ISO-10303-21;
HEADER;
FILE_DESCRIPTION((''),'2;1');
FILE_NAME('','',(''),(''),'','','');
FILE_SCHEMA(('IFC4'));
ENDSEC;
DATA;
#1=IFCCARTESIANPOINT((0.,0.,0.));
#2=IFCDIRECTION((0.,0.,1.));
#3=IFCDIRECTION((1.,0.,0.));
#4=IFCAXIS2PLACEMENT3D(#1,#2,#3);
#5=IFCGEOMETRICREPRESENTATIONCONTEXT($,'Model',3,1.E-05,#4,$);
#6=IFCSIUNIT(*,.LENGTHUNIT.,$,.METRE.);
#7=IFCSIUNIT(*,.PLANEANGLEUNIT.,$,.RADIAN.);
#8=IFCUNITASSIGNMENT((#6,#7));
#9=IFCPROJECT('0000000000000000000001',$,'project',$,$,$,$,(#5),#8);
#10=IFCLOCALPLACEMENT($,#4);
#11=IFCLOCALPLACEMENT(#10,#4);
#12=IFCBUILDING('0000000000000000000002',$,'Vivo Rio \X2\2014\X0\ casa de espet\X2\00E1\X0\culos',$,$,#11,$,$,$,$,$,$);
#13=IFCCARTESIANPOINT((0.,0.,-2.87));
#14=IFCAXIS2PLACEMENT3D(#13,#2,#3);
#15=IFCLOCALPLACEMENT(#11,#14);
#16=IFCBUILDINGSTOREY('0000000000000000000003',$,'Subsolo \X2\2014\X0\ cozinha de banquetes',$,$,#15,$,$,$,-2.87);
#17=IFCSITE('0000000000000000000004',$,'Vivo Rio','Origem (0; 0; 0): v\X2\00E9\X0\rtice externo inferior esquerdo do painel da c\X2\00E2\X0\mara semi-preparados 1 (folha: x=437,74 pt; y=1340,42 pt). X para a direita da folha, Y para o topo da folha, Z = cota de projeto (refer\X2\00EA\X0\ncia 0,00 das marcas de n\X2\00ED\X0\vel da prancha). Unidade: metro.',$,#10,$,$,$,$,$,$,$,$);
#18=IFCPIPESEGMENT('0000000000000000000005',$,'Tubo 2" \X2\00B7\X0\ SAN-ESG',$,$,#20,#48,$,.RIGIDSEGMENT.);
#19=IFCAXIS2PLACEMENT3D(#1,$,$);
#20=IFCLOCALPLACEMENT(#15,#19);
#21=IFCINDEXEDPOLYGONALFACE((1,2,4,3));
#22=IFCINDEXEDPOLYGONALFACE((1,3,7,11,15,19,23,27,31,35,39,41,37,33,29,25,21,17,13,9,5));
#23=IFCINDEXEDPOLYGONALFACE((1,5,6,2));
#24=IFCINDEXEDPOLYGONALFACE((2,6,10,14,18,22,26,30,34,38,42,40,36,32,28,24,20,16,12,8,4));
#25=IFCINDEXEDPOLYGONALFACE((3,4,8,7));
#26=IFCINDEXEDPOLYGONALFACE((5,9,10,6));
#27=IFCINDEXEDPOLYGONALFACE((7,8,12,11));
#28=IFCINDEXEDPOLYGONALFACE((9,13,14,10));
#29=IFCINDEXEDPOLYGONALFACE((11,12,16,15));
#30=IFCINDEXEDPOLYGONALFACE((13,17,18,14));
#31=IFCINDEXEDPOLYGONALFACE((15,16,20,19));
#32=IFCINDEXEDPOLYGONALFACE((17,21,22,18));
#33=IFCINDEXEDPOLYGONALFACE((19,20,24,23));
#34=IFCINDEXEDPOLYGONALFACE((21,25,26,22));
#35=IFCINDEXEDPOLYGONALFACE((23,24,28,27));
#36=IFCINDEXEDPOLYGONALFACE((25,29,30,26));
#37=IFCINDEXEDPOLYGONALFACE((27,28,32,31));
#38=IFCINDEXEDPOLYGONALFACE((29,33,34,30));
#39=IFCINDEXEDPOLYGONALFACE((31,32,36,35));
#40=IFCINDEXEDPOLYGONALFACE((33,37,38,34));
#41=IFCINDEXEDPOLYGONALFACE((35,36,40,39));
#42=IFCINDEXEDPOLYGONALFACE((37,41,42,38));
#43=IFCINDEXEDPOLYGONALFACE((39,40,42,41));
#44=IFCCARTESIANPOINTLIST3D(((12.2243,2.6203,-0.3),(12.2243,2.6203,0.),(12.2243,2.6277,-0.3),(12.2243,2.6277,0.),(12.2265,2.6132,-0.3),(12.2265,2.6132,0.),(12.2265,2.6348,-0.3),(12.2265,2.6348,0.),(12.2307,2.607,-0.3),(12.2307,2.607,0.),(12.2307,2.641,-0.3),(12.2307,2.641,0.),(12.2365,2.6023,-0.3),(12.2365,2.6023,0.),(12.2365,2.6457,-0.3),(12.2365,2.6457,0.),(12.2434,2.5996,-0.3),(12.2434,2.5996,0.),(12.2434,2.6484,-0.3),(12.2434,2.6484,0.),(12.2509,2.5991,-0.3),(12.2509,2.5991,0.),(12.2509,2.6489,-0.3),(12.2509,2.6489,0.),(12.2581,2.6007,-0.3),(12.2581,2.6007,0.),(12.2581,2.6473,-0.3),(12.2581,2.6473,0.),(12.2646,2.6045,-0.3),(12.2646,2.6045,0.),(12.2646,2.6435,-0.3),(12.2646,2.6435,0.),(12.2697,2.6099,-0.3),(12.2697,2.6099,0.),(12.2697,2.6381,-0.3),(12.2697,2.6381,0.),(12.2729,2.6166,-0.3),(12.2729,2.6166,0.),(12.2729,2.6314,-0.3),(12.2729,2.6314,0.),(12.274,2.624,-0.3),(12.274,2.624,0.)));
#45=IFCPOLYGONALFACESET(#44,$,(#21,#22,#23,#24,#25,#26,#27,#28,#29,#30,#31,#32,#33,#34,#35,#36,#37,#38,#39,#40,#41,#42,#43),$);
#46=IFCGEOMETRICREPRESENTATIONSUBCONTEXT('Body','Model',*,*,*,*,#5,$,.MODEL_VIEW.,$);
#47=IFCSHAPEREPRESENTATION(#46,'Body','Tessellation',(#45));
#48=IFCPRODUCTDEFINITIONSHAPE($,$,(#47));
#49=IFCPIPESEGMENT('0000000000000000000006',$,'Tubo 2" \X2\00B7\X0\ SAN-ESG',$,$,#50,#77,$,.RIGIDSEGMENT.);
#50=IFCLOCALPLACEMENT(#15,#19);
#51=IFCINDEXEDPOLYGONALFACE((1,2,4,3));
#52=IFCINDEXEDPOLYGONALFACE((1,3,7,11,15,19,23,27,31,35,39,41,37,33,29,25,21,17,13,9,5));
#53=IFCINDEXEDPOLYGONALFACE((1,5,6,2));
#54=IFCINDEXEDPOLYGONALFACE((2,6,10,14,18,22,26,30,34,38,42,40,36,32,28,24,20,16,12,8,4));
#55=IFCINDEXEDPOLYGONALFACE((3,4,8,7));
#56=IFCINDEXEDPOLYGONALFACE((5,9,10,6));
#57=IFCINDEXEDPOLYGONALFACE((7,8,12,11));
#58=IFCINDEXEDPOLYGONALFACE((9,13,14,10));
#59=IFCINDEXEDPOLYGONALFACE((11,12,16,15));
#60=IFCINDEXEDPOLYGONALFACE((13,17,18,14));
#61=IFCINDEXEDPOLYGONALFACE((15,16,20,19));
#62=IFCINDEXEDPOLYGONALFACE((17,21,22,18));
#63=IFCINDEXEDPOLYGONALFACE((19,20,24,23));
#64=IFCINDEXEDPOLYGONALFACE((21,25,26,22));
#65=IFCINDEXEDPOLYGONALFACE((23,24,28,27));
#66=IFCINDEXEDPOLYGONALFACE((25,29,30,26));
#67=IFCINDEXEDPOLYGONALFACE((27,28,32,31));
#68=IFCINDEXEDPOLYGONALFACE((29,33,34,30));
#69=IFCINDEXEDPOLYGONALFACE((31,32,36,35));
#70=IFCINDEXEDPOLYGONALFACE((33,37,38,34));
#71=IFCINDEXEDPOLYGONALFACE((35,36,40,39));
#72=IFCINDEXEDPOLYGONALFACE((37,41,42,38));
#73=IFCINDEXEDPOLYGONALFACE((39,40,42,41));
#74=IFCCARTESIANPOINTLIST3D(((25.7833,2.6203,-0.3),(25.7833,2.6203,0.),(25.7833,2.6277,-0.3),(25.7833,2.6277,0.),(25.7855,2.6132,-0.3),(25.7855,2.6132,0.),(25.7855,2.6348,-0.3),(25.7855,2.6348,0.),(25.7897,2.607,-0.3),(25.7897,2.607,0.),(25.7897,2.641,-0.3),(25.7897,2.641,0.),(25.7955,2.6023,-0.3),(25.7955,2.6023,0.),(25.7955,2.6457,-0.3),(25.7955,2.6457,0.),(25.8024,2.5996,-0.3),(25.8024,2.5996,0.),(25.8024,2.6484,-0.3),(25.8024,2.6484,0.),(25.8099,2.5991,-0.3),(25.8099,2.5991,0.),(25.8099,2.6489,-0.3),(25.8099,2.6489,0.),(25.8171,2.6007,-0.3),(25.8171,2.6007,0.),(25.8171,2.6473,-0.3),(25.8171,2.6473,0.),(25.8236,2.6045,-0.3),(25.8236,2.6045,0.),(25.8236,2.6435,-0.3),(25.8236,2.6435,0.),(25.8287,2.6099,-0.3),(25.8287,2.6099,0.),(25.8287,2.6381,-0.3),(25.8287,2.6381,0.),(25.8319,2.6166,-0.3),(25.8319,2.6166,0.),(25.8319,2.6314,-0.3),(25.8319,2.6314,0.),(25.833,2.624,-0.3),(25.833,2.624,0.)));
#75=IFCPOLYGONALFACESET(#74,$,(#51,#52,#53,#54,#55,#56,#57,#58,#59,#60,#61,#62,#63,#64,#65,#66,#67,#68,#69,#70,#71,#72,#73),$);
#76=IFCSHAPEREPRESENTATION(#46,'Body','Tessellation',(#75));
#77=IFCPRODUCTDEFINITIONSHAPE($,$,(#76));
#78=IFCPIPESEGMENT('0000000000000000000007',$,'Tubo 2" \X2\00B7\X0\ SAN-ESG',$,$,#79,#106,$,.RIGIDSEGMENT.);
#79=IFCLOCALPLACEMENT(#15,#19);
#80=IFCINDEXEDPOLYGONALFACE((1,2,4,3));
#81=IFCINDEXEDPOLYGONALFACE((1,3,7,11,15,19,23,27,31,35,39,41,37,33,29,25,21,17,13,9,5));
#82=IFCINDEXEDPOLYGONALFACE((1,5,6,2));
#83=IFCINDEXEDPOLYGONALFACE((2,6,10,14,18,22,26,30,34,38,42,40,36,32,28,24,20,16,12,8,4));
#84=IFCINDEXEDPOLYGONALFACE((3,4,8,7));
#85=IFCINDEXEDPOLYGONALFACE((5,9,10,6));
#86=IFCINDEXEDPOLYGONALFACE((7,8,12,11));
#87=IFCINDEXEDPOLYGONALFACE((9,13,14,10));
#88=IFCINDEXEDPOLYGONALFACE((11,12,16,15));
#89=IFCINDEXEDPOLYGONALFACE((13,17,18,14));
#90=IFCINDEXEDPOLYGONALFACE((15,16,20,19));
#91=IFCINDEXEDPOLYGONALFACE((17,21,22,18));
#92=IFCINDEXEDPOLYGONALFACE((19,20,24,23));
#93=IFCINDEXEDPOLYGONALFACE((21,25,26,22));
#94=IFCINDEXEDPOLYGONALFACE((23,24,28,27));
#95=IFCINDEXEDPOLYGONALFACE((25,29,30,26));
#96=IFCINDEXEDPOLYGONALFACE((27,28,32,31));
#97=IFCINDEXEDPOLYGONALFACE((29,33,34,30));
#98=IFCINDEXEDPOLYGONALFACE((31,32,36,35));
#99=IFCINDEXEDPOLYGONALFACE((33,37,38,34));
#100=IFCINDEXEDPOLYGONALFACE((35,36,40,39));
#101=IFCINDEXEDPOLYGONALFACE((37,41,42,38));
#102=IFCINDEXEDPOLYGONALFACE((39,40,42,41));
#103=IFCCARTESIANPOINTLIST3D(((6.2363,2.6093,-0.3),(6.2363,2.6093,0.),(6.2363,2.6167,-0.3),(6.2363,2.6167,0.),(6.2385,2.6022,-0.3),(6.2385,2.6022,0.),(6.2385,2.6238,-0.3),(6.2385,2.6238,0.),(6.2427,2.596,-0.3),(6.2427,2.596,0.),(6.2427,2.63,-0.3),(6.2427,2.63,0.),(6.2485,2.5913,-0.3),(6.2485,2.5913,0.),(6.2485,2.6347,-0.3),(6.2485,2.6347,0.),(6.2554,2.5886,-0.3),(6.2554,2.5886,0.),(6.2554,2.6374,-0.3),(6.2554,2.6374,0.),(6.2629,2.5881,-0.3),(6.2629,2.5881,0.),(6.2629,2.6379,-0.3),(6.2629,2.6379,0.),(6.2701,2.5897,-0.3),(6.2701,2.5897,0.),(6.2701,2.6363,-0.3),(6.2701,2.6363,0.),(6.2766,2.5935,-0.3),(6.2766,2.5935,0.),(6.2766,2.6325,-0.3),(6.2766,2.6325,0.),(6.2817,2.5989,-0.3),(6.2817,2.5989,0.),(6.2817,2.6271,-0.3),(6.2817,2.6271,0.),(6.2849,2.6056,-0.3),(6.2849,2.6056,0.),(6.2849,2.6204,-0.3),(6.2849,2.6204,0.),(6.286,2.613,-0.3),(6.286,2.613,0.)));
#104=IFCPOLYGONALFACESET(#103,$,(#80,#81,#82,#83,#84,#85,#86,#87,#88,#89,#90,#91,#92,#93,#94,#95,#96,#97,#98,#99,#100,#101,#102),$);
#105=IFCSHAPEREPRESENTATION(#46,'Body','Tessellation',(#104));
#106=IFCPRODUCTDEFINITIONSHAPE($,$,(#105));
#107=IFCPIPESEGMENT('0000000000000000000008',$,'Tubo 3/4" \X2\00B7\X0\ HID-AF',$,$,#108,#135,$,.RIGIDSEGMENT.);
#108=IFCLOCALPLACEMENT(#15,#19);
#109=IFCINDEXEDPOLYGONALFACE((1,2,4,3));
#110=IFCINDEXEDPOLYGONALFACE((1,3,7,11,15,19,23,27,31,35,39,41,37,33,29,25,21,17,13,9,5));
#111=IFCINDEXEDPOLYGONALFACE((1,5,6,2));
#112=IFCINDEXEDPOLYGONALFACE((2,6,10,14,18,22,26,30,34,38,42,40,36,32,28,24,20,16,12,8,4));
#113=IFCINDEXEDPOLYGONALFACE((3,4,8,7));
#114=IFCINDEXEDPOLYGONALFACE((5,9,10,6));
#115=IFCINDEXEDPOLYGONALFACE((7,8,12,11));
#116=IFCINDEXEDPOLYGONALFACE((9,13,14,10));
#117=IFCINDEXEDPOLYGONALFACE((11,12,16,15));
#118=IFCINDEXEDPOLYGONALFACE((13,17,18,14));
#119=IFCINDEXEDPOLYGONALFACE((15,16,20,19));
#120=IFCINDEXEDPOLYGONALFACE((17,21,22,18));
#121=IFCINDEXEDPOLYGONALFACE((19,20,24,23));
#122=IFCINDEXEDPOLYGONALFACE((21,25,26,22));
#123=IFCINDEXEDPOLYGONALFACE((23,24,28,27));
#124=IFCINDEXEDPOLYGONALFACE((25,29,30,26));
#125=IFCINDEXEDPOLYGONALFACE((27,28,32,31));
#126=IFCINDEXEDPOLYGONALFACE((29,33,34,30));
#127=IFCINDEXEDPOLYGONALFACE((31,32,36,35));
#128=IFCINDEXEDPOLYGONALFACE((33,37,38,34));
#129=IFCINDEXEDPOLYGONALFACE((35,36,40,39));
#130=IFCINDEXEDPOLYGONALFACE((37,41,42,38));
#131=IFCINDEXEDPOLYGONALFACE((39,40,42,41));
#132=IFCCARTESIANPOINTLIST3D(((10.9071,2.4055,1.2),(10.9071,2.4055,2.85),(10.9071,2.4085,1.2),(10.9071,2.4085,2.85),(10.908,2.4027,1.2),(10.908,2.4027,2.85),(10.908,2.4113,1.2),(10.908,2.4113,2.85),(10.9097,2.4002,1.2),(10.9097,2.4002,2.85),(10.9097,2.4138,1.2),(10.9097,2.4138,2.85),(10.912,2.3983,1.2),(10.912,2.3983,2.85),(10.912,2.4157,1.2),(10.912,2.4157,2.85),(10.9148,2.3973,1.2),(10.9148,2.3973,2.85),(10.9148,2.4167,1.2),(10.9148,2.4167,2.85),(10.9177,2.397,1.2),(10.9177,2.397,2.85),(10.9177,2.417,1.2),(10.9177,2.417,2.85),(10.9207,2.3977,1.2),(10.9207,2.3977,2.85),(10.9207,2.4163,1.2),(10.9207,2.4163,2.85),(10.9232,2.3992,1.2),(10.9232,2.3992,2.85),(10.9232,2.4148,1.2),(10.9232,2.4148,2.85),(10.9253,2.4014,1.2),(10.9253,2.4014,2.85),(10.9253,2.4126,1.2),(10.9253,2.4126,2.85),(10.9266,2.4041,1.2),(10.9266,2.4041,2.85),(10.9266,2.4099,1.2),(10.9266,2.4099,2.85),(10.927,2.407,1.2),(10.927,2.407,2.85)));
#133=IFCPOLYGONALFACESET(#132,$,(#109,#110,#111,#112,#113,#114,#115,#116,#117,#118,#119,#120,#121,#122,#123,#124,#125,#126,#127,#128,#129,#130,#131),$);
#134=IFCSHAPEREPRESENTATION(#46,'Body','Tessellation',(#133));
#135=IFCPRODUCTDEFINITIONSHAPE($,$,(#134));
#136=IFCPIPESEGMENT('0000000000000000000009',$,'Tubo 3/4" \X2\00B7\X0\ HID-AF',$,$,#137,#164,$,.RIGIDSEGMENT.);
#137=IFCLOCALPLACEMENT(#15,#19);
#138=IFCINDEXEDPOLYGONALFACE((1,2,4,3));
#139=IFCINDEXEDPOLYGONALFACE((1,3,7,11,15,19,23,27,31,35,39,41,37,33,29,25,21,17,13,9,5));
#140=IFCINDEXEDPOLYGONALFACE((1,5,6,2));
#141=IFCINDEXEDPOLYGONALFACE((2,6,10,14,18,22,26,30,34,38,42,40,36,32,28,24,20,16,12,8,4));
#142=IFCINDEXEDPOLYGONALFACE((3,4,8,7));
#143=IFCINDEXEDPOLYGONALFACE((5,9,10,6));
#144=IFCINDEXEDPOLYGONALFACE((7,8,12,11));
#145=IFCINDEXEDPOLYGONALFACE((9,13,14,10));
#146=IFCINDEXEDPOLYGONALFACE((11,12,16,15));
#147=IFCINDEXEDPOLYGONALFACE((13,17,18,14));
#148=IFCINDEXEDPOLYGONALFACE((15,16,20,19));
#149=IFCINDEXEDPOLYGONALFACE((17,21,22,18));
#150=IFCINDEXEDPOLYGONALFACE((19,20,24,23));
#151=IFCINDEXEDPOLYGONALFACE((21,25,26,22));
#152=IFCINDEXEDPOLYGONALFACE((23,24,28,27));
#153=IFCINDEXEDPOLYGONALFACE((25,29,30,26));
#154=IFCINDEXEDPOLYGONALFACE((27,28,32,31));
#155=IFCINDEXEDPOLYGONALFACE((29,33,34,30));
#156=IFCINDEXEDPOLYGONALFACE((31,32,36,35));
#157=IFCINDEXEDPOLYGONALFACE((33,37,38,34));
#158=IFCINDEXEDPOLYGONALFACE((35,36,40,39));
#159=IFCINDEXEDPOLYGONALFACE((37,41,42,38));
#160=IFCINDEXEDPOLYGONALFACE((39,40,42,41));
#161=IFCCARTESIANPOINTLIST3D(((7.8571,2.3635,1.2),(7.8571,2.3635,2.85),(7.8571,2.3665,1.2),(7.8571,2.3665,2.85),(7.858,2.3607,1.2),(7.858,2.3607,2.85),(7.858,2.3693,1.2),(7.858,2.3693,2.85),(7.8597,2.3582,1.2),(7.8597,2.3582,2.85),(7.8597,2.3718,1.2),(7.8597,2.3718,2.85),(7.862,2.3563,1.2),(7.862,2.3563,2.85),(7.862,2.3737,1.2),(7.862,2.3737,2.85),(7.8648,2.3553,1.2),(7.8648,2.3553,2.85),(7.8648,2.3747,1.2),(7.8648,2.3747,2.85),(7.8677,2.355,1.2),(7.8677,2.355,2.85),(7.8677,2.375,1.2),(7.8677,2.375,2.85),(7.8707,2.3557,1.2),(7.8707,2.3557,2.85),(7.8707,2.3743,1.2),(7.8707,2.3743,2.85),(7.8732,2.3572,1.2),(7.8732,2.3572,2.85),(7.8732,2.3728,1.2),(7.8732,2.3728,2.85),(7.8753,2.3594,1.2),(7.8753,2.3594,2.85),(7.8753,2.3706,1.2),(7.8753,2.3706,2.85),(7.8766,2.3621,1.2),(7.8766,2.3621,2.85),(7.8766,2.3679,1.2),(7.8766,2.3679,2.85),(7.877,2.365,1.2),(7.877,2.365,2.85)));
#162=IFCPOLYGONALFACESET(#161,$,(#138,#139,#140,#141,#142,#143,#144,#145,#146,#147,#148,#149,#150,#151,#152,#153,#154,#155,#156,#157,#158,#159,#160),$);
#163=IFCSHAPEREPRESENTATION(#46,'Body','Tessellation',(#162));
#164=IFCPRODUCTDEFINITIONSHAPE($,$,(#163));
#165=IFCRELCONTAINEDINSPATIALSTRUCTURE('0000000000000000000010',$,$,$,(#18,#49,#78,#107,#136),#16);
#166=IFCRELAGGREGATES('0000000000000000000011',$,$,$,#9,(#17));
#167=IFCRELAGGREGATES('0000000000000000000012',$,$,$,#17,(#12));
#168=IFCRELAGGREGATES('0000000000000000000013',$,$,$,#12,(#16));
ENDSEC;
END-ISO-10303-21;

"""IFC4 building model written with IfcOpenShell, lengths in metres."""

from ifc_helpers import new_model, si_unit, frame, origin_with_axes, origin_2d, place, context, subcontext, project, spatial, circle, extrude, element, save


model = new_model("IFC4")

# Units and contexts
model_context = context("Model", 3, precision=1e-05, world=origin_with_axes())
body_context = subcontext(model_context, "Body", "Model", "MODEL_VIEW")
ifc_project = project(units=[si_unit("LENGTHUNIT", "METRE"), si_unit("PLANEANGLEUNIT", "RADIAN")], contexts=[model_context])

# Site, building, storey
site_placement = place(None, origin_with_axes())
site = spatial("IfcSite", under=ifc_project, at=site_placement, Name="Vivo Rio", Description="Origem (0; 0; 0): vértice externo inferior esquerdo do painel da câmara semi-preparados 1 (folha: x=437,74 pt; y=1340,42 pt). X para a direita da folha, Y para o topo da folha, Z = cota de projeto (referência 0,00 das marcas de nível da prancha). Unidade: metro.")
building_placement = place(site_placement, origin_with_axes())
building = spatial("IfcBuilding", under=site, at=building_placement, Name="Vivo Rio — casa de espetáculos")
storey_placement = place(building_placement, frame((0.0, 0.0, -2.87), z_axis=(0.0, 0.0, 1.0), x_axis=(1.0, 0.0, 0.0)))
storey = spatial("IfcBuildingStorey", under=building, at=storey_placement, Name="Subsolo — cozinha de banquetes", Elevation=-2.87)

# Pipe segments
pipe_segment_1_placement = place(storey_placement, origin_with_axes())
element("IfcPipeSegment", 1, at=pipe_segment_1_placement, inside=storey, Name="Tubo 2\" · SAN-ESG", PredefinedType="RIGIDSEGMENT", context=body_context, shape_type="SweptSolid", body=[
    extrude(circle(Radius=0.025, at=origin_2d()), frame((12.249, 2.624, 0.0), z_axis=(0.0, 0.0, -1.0), x_axis=(1.0, 0.0, 0.0)), (0.0, 0.0, 1.0), 0.3),
])
pipe_segment_2_placement = place(storey_placement, origin_with_axes())
element("IfcPipeSegment", 2, at=pipe_segment_2_placement, inside=storey, Name="Tubo 2\" · SAN-ESG", PredefinedType="RIGIDSEGMENT", context=body_context, shape_type="SweptSolid", body=[
    extrude(circle(Radius=0.025, at=origin_2d()), frame((25.808, 2.624, 0.0), z_axis=(0.0, 0.0, -1.0), x_axis=(1.0, 0.0, 0.0)), (0.0, 0.0, 1.0), 0.3),
])
pipe_segment_3_placement = place(storey_placement, origin_with_axes())
element("IfcPipeSegment", 3, at=pipe_segment_3_placement, inside=storey, Name="Tubo 2\" · SAN-ESG", PredefinedType="RIGIDSEGMENT", context=body_context, shape_type="SweptSolid", body=[
    extrude(circle(Radius=0.025, at=origin_2d()), frame((6.261, 2.613, 0.0), z_axis=(0.0, 0.0, -1.0), x_axis=(1.0, 0.0, 0.0)), (0.0, 0.0, 1.0), 0.3),
])
pipe_segment_4_placement = place(storey_placement, origin_with_axes())
element("IfcPipeSegment", 4, at=pipe_segment_4_placement, inside=storey, Name="Tubo 3/4\" · HID-AF", PredefinedType="RIGIDSEGMENT", context=body_context, shape_type="SweptSolid", body=[
    extrude(circle(Radius=0.01, at=origin_2d()), frame((10.917, 2.407, 2.85), z_axis=(0.0, 0.0, -1.0), x_axis=(1.0, 0.0, 0.0)), (0.0, 0.0, 1.0), 1.65),
])
pipe_segment_5_placement = place(storey_placement, origin_with_axes())
element("IfcPipeSegment", 5, at=pipe_segment_5_placement, inside=storey, Name="Tubo 3/4\" · HID-AF", PredefinedType="RIGIDSEGMENT", context=body_context, shape_type="SweptSolid", body=[
    extrude(circle(Radius=0.01, at=origin_2d()), frame((7.867, 2.365, 2.85), z_axis=(0.0, 0.0, -1.0), x_axis=(1.0, 0.0, 0.0)), (0.0, 0.0, 1.0), 1.65),
])

save(model, "model.ifc")
